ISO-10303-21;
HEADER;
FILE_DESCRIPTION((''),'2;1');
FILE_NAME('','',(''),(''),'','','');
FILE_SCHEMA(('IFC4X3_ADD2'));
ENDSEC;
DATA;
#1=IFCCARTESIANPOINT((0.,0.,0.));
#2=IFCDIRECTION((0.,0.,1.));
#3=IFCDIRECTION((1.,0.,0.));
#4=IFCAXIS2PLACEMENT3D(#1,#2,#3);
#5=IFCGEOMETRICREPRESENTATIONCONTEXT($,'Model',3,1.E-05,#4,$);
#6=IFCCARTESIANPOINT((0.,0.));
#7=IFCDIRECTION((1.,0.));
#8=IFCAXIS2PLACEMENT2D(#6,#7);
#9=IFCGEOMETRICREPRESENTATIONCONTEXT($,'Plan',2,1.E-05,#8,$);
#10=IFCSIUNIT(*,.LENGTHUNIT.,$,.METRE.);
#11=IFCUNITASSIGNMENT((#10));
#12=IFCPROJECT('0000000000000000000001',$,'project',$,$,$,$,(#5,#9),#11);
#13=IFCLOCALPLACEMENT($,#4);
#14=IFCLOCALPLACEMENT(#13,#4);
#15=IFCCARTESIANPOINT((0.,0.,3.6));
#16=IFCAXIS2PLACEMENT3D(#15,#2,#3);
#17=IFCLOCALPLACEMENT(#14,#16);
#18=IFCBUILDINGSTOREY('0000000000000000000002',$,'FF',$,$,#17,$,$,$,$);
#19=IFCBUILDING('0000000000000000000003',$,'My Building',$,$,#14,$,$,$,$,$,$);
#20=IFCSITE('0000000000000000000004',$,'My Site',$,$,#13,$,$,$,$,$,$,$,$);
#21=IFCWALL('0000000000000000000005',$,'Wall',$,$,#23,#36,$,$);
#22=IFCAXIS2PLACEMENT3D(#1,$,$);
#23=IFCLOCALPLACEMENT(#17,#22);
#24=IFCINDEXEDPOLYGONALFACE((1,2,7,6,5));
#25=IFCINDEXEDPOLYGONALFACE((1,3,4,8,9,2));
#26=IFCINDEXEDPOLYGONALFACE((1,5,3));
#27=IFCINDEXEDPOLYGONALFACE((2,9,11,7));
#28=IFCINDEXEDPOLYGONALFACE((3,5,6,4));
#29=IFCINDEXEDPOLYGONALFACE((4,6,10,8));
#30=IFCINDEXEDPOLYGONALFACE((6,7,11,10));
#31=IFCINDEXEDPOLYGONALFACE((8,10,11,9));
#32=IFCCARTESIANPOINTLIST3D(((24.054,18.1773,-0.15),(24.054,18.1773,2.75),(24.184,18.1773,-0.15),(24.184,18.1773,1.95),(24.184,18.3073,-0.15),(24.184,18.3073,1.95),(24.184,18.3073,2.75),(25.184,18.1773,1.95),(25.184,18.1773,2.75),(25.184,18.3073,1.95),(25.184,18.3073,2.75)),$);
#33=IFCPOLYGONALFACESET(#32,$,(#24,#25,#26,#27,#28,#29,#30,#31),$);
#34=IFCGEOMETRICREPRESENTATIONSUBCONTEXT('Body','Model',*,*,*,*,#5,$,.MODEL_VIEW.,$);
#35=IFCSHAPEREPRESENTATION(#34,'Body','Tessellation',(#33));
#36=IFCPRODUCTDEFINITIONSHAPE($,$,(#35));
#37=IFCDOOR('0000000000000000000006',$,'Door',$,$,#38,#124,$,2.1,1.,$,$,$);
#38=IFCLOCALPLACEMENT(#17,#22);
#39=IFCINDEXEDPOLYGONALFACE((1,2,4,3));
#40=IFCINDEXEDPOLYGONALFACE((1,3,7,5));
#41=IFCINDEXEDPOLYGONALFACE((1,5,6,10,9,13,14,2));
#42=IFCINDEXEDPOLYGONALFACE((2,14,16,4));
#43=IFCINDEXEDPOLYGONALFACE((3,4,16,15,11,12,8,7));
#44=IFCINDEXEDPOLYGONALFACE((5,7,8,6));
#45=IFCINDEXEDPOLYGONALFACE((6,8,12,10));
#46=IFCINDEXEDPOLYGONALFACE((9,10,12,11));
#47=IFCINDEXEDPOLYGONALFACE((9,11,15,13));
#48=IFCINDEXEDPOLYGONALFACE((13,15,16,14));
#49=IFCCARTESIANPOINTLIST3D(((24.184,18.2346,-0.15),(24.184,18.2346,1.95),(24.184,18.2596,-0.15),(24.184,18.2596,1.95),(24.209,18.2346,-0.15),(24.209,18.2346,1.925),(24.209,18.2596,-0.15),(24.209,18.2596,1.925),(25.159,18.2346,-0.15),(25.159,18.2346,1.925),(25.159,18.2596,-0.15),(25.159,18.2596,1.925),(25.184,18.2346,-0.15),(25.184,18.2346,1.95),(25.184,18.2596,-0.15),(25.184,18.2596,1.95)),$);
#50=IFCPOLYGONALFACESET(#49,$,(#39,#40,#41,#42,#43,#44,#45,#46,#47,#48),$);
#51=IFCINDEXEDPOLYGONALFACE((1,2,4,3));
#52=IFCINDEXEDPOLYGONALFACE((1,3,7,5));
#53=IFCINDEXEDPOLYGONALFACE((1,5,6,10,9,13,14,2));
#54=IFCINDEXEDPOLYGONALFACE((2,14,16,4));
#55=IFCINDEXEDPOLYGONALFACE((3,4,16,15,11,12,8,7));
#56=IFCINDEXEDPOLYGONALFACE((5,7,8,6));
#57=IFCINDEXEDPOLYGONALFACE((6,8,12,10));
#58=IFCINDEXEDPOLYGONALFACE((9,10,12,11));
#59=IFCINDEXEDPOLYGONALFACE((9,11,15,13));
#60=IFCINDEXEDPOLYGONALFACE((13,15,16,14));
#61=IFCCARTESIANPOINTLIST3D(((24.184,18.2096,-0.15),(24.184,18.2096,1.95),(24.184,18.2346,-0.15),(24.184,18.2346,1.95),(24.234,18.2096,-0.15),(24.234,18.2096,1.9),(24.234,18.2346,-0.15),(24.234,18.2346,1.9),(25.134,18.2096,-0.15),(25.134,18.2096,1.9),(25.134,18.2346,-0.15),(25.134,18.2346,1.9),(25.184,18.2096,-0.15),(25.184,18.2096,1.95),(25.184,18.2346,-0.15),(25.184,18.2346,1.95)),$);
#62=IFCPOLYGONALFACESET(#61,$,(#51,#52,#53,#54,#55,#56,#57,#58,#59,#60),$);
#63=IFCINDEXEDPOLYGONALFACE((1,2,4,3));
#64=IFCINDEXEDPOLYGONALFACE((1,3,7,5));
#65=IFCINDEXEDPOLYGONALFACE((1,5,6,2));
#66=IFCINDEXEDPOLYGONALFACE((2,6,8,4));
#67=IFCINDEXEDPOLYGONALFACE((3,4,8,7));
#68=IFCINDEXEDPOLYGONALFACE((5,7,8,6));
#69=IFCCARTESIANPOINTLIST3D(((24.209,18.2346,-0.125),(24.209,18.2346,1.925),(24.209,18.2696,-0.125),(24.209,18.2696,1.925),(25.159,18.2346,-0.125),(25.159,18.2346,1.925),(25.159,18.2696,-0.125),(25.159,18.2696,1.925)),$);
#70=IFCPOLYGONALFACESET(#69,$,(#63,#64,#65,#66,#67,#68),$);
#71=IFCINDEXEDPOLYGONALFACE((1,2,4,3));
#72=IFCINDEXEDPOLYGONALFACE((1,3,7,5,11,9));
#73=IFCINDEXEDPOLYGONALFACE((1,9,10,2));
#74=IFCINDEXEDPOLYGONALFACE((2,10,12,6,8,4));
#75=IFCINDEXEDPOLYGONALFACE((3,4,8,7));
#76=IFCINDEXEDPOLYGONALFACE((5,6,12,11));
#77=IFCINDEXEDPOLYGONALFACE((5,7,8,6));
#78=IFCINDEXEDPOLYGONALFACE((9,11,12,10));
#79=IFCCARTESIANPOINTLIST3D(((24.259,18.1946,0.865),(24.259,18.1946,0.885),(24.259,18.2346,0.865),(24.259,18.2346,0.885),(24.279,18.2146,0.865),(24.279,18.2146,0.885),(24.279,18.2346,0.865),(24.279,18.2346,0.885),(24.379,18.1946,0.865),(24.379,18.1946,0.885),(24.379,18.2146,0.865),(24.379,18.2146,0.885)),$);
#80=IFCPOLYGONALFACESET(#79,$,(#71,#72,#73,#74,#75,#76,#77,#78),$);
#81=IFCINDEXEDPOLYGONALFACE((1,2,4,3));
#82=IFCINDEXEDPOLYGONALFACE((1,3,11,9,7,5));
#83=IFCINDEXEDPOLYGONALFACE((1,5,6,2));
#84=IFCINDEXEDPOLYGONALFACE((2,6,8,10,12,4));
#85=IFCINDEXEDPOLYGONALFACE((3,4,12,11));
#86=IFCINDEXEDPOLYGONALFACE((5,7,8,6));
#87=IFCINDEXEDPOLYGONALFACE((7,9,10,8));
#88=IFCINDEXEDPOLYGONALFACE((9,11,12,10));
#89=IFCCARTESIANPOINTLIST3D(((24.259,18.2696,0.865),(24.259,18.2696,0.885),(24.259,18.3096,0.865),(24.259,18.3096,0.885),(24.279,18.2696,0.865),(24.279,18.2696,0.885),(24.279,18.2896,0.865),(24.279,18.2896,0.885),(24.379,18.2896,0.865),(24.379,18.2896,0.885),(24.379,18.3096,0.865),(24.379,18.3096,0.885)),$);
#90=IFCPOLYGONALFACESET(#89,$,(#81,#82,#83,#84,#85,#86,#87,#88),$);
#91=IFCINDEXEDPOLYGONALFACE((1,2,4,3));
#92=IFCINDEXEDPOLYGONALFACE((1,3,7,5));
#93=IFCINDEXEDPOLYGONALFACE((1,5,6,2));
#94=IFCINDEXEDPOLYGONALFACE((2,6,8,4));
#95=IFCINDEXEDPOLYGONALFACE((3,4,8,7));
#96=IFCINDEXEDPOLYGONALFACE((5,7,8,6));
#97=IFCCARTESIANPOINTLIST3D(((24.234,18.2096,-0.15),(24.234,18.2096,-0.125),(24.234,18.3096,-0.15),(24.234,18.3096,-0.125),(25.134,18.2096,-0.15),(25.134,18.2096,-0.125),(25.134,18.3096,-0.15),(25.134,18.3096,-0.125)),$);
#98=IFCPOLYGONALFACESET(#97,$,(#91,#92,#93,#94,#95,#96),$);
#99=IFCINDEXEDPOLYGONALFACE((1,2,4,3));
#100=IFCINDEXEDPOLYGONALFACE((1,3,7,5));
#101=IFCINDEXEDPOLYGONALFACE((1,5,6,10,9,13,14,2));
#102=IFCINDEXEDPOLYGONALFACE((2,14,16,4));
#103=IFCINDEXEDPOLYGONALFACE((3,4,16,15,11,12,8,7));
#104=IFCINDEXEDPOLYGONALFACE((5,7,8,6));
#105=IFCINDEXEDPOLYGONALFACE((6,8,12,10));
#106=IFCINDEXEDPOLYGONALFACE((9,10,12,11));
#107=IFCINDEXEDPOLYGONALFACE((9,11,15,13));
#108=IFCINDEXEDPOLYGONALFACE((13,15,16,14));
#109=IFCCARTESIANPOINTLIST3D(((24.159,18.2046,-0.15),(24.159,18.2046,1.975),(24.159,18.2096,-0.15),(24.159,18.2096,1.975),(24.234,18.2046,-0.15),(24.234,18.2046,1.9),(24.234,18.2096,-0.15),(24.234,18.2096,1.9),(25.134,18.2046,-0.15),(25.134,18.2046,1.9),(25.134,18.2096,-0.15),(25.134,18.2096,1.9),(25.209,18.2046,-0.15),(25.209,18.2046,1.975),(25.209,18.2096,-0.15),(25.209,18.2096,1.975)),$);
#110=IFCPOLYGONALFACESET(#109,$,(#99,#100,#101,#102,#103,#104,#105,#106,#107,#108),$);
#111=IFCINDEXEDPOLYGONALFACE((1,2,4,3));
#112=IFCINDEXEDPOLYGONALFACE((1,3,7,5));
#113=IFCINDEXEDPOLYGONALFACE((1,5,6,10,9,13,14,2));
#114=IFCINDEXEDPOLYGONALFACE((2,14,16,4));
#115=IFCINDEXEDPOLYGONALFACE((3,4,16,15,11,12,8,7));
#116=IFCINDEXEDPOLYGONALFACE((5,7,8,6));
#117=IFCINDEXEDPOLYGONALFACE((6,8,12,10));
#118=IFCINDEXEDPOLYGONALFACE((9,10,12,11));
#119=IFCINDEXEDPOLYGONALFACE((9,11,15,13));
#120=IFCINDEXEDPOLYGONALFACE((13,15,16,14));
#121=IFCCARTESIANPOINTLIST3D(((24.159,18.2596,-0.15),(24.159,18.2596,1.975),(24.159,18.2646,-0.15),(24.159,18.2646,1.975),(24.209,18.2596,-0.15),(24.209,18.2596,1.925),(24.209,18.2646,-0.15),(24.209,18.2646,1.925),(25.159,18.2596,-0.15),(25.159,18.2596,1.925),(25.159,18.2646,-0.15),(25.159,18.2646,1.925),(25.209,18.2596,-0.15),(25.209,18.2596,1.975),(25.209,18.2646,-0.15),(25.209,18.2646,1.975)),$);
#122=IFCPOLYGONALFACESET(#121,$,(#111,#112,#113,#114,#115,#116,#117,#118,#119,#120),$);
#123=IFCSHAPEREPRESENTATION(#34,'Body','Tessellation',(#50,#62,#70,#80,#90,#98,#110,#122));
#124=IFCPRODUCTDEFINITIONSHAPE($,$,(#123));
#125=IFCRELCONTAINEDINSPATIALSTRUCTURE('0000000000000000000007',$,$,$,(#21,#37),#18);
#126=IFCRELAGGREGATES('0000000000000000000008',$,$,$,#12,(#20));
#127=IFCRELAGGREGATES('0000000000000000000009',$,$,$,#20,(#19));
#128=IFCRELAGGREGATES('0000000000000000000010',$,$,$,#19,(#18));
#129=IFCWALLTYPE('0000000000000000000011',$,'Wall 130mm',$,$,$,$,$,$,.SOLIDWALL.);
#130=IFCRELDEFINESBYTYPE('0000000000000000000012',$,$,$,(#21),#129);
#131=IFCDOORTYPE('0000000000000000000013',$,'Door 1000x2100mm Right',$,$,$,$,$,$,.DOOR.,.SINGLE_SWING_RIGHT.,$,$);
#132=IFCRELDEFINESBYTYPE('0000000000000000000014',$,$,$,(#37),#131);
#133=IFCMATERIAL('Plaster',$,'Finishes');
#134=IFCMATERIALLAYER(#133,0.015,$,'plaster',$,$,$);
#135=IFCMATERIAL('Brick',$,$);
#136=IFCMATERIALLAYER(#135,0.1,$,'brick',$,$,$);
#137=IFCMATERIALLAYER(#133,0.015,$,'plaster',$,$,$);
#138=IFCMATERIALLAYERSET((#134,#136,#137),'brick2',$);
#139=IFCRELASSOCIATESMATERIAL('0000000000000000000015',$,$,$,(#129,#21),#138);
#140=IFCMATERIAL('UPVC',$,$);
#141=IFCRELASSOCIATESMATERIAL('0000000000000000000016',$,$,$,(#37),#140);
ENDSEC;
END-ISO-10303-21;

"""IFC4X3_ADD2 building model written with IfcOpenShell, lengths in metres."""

from ifc_helpers import new_model, entity, si_unit, frame, origin_with_axes, origin_2d_with_axis, place, context, subcontext, project, spatial, line, indexed_curve, outline, extrude, shape, source, transform, mapped, material, layer, layer_set, layer_usage, type_object, type_shapes, element, fill, save


model = new_model("IFC4X3_ADD2")

# Units and contexts
model_context = context("Model", 3, precision=1e-05, world=origin_with_axes())
plan_context = context("Plan", 2, precision=1e-05, world=origin_2d_with_axis())
body_context_1 = subcontext(model_context, "Body", "Model", "MODEL_VIEW")
body_context_2 = subcontext(plan_context, "Body", "Plan", "PLAN_VIEW")
ifc_project = project(units=[si_unit("LENGTHUNIT", "METRE")], contexts=[model_context, plan_context])

# Site, building, storey
site_placement = place(None, origin_with_axes())
site = spatial("IfcSite", under=ifc_project, at=site_placement, Name="My Site")
building_placement = place(site_placement, origin_with_axes())
building = spatial("IfcBuilding", under=site, at=building_placement, Name="My Building")
storey_placement = place(building_placement, frame((0.0, 0.0, 3.6), z_axis=(0.0, 0.0, 1.0), x_axis=(1.0, 0.0, 0.0)))
storey = spatial("IfcBuildingStorey", under=building, at=storey_placement, Name="FF")

# Shared definitions
ifc_material_1 = material(Name="UPVC")

# Shared definitions
ifc_material_2 = material(Name="Plaster", Category="Finishes")
ifc_material_3 = material(Name="Brick")

# Shared definitions
shared_shape_1 = source(origin_with_axes(), body_context_1, "Body", "SweptSolid", [
    extrude(outline(indexed_curve([(0.0, 2.1), (1.0, 2.1), (1.0, -0.05), (0.0, -0.05), (0.0, 2.1)])), frame((0.0, -0.6, 0.0), z_axis=(0.0, -1.0, 0.0), x_axis=(1.0, 0.0, 0.0)), (0.0, 0.0, -1.0), 1.2),
])
door_type_1 = type_object("IfcDoorType", Name="Door 1000x2100mm Right", OperationType="SINGLE_SWING_RIGHT", PredefinedType="DOOR")
shared_shape_2 = source(origin_with_axes(), body_context_1, "Body", "SweptSolid", [
    extrude(outline(indexed_curve([(0.0, 0.0), (0.0, 2.1), (1.0, 2.1), (1.0, 0.0), (0.975, 0.0), (0.975, 2.075), (0.025, 2.075), (0.025, 0.0)], segments=[line(1, 2, 3, 4, 5, 6, 7, 8, 1)])), frame((0.0, 0.025, 0.0), z_axis=(0.0, -1.0, 0.0), x_axis=(1.0, 0.0, 0.0)), (0.0, 0.0, -1.0), 0.025),
    extrude(outline(indexed_curve([(0.0, 0.0), (0.0, 2.1), (1.0, 2.1), (1.0, 0.0), (0.95, 0.0), (0.95, 2.05), (0.05, 2.05), (0.05, 0.0)], segments=[line(1, 2, 3, 4, 5, 6, 7, 8, 1)])), frame((0.0, 0.0, 0.0), z_axis=(0.0, -1.0, 0.0), x_axis=(1.0, 0.0, 0.0)), (0.0, 0.0, -1.0), 0.025),
    extrude(outline(indexed_curve([(0.0, 0.0), (0.95, 0.0), (0.95, 0.035), (0.0, 0.035)], segments=[line(1, 2, 3, 4, 1)])), frame((0.025, 0.025, 0.025), z_axis=(0.0, 0.0, 1.0), x_axis=(1.0, 0.0, 0.0)), (0.0, 0.0, 1.0), 2.05),
    extrude(outline(indexed_curve([(0.0, 0.0), (0.0, -0.04), (0.12, -0.04), (0.12, -0.02), (0.02, -0.02), (0.02, 0.0)], segments=[line(1, 2, 3, 4, 5, 6, 1)])), frame((0.075, 0.025, 1.015), z_axis=(0.0, 0.0, 1.0), x_axis=(1.0, 0.0, 0.0)), (0.0, 0.0, 1.0), 0.02),
    extrude(outline(indexed_curve([(0.0, 0.0), (0.0, 0.04), (0.12, 0.04), (0.12, 0.02), (0.02, 0.02), (0.02, 0.0)], segments=[line(1, 2, 3, 4, 5, 6, 1)])), frame((0.075, 0.06, 1.015), z_axis=(0.0, 0.0, 1.0), x_axis=(1.0, 0.0, 0.0)), (0.0, 0.0, 1.0), 0.02),
    extrude(outline(indexed_curve([(0.0, 0.0), (0.9, 0.0), (0.9, 0.1), (0.0, 0.1)], segments=[line(1, 2, 3, 4, 1)])), frame((0.05, 0.0, 0.0), z_axis=(0.0, 0.0, 1.0), x_axis=(1.0, 0.0, 0.0)), (0.0, 0.0, 1.0), 0.025),
    extrude(outline(indexed_curve([(0.0, 0.0), (0.0, 2.125), (1.05, 2.125), (1.05, 0.0), (0.975, 0.0), (0.975, 2.05), (0.075, 2.05), (0.075, 0.0)], segments=[line(1, 2, 3, 4, 5, 6, 7, 8, 1)])), frame((-0.025, -0.005, 0.0), z_axis=(0.0, -1.0, 0.0), x_axis=(1.0, 0.0, 0.0)), (0.0, 0.0, -1.0), 0.005),
    extrude(outline(indexed_curve([(0.0, 0.0), (0.0, 2.125), (1.05, 2.125), (1.05, 0.0), (1.0, 0.0), (1.0, 2.075), (0.05, 2.075), (0.05, 0.0)], segments=[line(1, 2, 3, 4, 5, 6, 7, 8, 1)])), frame((-0.025, 0.05, 0.0), z_axis=(0.0, -1.0, 0.0), x_axis=(1.0, 0.0, 0.0)), (0.0, 0.0, -1.0), 0.005),
])
shared_shape_3 = source(origin_with_axes(), body_context_2, "Body", "Curve2D", [
    entity("IfcIndexedPolyCurve", entity("IfcCartesianPointList2D", [[0.0, 0.0], [0.0, 0.05], [0.025, 0.05], [0.025, 0.025], [0.05, 0.025], [0.05, 0.0]]), [entity("IfcLineIndex", [1, 2, 3, 4, 5, 6, 1])]),
    entity("IfcIndexedPolyCurve", entity("IfcCartesianPointList2D", [[1.0, 0.0], [1.0, 0.05], [0.975, 0.05], [0.975, 0.025], [0.95, 0.025], [0.95, 0.0]]), [entity("IfcLineIndex", [1, 2, 3, 4, 5, 6, 1])]),
    entity("IfcTrimmedCurve", entity("IfcEllipse", entity("IfcAxis2Placement2D", entity("IfcCartesianPoint", [0.94, 0.05]), entity("IfcDirection", [1.0, 0.0])), 0.915, 0.95), [entity("IfcCartesianPoint", [0.94, 1.0])], [entity("IfcCartesianPoint", [0.025, 0.05])], True, "CARTESIAN"),
    entity("IfcIndexedPolyCurve", entity("IfcCartesianPointList2D", [[0.975, 0.05], [0.94, 0.05], [0.94, 1.0], [0.975, 1.0]]), [entity("IfcLineIndex", [1, 2, 3, 4, 1])]),
])
type_shapes(door_type_1, [shared_shape_2, shared_shape_3])

# Shared definitions
ifc_layer_1 = layer(ifc_material_2, 0.015, Name="plaster")
ifc_layer_2 = layer(ifc_material_3, 0.1, Name="brick")
ifc_layer_3 = layer(ifc_material_2, 0.015, Name="plaster")
ifc_layer_set_1 = layer_set([ifc_layer_1, ifc_layer_2, ifc_layer_3], Name="brick2")
wall_type_1 = type_object("IfcWallType", Name="Wall 130mm", PredefinedType="SOLIDWALL", material=ifc_layer_set_1)

# Wall, opening, door
ifc_layer_usage_1 = layer_usage(ifc_layer_set_1, "AXIS2", "POSITIVE", 0.0)
wall_1_placement = place(storey_placement, frame((25.434, 18.3073, -0.15), z_axis=(0.0, 0.0, 1.0), x_axis=(-1.0, 0.0, 0.0)))
wall_1 = element("IfcWall", 1, at=wall_1_placement, inside=storey, type_object=wall_type_1, material=ifc_layer_usage_1, Name="Wall", context=body_context_1, shape_type="SweptSolid", body=[
    extrude(outline(indexed_curve([(0.25, 0.0), (0.25, 0.13), (1.38, 0.13), (1.25, 0.0)], segments=[line(1, 2, 3, 4, 1)])), origin_with_axes(), (0.0, 0.0, 1.0), 2.9),
])
opening_1_placement = place(wall_1_placement, frame((1.25, 0.0802, 0.0), z_axis=(0.0, 0.0, 1.0), x_axis=(-1.0, 0.0, 0.0)))
opening_1 = element("IfcOpeningElement", 2, at=opening_1_placement, cuts=wall_1, PredefinedType="OPENING", context=body_context_1, shape_type="MappedRepresentation", body=[
    mapped(shared_shape_1, transform((0.0, 0.0, 0.0), x_axis=(1.0, 0.0, 0.0), y_axis=(0.0, 1.0, 0.0), z_axis=(0.0, 0.0, 1.0), scale=1.0)),
])
door_1_placement = place(opening_1_placement, frame((0.0, -0.0175, 0.0), z_axis=(0.0, 0.0, 1.0), x_axis=(1.0, 0.0, 0.0)))
door_1 = element("IfcDoor", 3, at=door_1_placement, inside=storey, type_object=door_type_1, material=ifc_material_1, Name="Door", OverallHeight=2.1, OverallWidth=1.0, shapes=[
    shape(body_context_1, "Body", "MappedRepresentation", [mapped(shared_shape_2, transform((0.0, 0.0, 0.0), x_axis=(1.0, 0.0, 0.0), y_axis=(0.0, 1.0, 0.0), z_axis=(0.0, 0.0, 1.0), scale=1.0))]),
    shape(body_context_2, "Body", "MappedRepresentation", [mapped(shared_shape_3, transform((0.0, 0.0, 0.0), x_axis=(1.0, 0.0, 0.0), y_axis=(0.0, 1.0, 0.0), z_axis=(0.0, 0.0, 1.0), scale=1.0))]),
])
fill(opening_1, door_1)

save(model, "model.ifc")
